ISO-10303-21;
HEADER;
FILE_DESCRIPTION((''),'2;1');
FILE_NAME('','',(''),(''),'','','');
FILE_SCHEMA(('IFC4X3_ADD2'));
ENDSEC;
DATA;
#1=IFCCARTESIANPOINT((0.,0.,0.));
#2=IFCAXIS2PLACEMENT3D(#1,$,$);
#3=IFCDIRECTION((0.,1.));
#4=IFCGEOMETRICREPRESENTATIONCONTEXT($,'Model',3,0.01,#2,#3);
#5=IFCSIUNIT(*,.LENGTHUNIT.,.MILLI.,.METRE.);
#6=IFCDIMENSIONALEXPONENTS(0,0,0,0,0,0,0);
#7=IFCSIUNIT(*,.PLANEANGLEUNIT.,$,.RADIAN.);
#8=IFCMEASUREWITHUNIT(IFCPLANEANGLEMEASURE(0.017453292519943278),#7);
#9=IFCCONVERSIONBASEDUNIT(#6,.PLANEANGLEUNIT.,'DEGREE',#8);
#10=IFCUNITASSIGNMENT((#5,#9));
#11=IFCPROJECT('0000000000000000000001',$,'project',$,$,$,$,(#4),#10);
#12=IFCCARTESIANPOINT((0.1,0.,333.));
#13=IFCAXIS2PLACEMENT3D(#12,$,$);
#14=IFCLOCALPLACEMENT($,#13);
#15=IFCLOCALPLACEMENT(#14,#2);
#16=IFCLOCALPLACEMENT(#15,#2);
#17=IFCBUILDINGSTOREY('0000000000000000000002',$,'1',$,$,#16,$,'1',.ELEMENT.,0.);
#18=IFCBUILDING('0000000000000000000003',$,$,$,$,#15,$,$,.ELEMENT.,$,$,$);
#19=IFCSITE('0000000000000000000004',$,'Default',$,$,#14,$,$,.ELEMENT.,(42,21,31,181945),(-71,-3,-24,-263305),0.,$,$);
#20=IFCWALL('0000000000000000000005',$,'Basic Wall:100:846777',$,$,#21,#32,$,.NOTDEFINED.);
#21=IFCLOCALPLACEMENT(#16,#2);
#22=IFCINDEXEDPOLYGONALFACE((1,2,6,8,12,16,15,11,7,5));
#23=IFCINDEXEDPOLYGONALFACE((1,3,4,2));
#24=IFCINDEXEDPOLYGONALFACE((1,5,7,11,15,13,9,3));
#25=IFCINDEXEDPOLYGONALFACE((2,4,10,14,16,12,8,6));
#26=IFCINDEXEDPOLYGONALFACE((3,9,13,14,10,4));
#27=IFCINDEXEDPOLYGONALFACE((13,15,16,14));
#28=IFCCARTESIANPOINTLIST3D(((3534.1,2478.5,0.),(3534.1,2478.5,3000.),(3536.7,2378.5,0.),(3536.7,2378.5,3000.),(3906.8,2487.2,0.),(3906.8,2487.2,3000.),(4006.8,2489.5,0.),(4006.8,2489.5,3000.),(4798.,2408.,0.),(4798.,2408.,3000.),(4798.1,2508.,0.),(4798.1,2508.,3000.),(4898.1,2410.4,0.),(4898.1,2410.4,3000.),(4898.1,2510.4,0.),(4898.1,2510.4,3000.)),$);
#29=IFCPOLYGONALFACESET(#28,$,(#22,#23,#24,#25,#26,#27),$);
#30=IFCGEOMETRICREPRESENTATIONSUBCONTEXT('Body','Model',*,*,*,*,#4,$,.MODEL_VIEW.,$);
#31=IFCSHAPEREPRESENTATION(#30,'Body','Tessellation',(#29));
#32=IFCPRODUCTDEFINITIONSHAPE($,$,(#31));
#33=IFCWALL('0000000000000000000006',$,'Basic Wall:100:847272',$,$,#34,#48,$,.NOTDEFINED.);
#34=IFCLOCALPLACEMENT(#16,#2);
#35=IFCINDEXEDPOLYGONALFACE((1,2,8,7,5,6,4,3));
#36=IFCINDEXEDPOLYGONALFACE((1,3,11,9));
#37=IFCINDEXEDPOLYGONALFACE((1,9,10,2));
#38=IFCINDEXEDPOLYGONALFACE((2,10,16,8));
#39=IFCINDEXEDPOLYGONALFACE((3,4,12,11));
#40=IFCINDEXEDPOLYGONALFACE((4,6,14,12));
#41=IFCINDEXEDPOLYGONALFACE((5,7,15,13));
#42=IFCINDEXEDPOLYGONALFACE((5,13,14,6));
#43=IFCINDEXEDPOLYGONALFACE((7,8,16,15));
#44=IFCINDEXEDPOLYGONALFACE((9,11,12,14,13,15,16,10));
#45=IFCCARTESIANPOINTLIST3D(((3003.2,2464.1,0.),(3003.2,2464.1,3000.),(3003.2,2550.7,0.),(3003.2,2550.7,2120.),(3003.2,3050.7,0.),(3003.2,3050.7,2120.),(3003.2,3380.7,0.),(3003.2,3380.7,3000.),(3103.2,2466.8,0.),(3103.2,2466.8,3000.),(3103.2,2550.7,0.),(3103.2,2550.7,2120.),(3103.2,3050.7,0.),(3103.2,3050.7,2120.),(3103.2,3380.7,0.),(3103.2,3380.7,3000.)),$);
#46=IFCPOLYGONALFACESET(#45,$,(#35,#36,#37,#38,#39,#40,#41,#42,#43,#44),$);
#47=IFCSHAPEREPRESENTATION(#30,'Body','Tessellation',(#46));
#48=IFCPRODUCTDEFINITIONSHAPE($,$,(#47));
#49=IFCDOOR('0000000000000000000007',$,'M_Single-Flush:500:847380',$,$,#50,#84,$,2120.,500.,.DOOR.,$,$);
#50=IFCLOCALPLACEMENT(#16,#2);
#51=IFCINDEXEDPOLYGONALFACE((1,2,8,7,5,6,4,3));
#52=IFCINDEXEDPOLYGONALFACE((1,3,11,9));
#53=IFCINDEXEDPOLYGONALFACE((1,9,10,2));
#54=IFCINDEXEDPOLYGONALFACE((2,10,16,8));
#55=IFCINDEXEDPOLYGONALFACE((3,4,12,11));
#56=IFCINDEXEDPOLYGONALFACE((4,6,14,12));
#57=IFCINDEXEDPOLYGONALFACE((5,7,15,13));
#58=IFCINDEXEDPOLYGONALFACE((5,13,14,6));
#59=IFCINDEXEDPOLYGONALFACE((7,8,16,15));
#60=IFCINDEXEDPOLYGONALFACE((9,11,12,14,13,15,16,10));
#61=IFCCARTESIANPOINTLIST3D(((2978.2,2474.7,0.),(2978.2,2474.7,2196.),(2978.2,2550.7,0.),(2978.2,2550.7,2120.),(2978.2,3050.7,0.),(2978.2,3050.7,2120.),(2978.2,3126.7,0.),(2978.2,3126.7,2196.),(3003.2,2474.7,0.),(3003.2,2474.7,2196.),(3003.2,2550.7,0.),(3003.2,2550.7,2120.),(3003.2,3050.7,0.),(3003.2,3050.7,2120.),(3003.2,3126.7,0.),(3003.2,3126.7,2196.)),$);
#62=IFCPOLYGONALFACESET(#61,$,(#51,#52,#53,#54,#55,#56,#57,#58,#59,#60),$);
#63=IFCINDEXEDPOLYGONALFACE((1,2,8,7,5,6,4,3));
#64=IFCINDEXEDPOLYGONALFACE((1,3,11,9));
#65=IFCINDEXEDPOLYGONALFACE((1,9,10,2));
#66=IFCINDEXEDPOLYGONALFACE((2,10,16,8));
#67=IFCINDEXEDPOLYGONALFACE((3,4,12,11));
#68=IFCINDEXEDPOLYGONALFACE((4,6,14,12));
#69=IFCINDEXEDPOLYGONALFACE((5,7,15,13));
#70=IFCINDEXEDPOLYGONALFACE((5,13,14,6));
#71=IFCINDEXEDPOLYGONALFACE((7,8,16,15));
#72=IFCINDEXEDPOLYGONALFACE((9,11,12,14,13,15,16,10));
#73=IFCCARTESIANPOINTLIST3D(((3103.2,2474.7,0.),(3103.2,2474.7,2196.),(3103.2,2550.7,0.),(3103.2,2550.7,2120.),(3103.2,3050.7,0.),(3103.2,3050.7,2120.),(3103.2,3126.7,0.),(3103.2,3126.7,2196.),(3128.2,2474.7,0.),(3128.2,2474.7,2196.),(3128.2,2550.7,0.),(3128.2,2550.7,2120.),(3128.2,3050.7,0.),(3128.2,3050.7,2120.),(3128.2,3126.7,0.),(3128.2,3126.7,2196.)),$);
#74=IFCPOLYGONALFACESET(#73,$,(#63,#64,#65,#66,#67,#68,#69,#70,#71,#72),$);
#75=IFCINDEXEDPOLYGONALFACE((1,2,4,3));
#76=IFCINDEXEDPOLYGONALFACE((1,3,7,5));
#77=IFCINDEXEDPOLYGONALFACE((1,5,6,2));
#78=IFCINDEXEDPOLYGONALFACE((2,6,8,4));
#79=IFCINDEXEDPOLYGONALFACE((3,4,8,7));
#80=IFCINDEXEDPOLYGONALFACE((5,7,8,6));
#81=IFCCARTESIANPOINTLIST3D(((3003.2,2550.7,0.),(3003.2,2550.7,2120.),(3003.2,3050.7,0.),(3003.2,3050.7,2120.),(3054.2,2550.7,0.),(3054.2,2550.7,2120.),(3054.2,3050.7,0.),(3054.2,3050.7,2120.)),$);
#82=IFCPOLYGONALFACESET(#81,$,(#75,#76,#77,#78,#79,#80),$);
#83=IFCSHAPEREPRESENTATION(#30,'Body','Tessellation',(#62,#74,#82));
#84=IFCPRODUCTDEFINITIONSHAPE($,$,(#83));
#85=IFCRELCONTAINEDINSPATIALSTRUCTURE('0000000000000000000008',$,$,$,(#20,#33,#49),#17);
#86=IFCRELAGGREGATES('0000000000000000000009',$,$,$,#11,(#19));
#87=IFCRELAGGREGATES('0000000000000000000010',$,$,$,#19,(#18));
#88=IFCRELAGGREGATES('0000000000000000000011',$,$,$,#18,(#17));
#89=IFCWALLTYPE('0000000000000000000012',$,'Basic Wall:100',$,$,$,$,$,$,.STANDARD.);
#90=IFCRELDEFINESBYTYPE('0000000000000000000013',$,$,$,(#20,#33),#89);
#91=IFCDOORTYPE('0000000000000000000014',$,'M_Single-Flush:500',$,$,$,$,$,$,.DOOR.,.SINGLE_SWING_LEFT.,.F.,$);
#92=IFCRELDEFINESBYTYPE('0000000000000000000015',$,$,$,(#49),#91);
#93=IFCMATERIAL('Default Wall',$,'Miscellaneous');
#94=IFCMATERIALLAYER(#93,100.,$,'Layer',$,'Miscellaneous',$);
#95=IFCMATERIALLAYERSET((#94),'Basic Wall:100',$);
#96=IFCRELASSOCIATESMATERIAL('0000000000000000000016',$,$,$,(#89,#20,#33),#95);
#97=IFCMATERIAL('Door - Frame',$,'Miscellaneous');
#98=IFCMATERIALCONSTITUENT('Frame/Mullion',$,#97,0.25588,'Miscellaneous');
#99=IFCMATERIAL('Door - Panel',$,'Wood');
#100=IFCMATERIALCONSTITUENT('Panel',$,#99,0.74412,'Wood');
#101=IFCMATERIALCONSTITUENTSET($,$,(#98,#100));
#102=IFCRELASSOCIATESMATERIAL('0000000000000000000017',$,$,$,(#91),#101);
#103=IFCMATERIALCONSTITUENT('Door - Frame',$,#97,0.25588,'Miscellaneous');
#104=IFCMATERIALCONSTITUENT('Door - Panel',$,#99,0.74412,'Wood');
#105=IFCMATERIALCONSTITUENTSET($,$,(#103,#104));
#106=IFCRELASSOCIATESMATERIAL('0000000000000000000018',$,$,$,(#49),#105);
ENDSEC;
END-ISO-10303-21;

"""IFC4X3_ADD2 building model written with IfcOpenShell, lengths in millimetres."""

from ifc_helpers import new_model, entity, si_unit, converted_unit, direction, frame, frame_2d, origin, origin_2d_with_axis, place, context, subcontext, project, spatial, polyline, rectangle, outline, extrude, source, transform, mapped, material, layer, layer_set, constituent, constituent_set, type_object, type_shapes, element, fill, save


model = new_model("IFC4X3_ADD2")

# Units and contexts
model_context = context("Model", 3, precision=0.01, world=origin(), true_north=direction((0.0, 1.0)))
body_context = subcontext(model_context, "Body", "Model", "MODEL_VIEW")
ifc_project = project(units=[si_unit("LENGTHUNIT", "METRE", prefix="MILLI"), converted_unit("PLANEANGLEUNIT", "DEGREE", entity("IfcPlaneAngleMeasure", 0.017453292519943278), si_unit("PLANEANGLEUNIT", "RADIAN"), dimensions=[0, 0, 0, 0, 0, 0, 0])], contexts=[model_context])

# Site, building, storey
site_placement = place(None, frame((0.1, 0.0, 333.0)))
site = spatial("IfcSite", under=ifc_project, at=site_placement, Name="Default", CompositionType="ELEMENT", RefLatitude=(42, 21, 31, 181945), RefLongitude=(-71, -3, -24, -263305), RefElevation=0.0)
building_placement = place(site_placement, origin())
building = spatial("IfcBuilding", under=site, at=building_placement, CompositionType="ELEMENT")
storey_placement = place(building_placement, origin())
storey = spatial("IfcBuildingStorey", under=building, at=storey_placement, Name="1", LongName="1", CompositionType="ELEMENT", Elevation=0.0)

# Shared definitions
ifc_material_1 = material(Name="Default Wall", Category="Miscellaneous")

# Shared definitions
ifc_layer_1 = layer(ifc_material_1, 100.0, Name="Layer", Category="Miscellaneous")
ifc_layer_set_1 = layer_set([ifc_layer_1], Name="Basic Wall:100")
wall_type_1 = type_object("IfcWallType", Name="Basic Wall:100", PredefinedType="STANDARD", material=ifc_layer_set_1)

# Shared definitions
ifc_material_2 = material(Name="Door - Frame", Category="Miscellaneous")
ifc_material_3 = material(Name="Door - Panel", Category="Wood")

# Wall
wall_1_placement = place(storey_placement, frame((3535.3, 2428.5, 0.0), z_axis=(0.0, 0.0, 1.0), x_axis=(0.999727, 0.023385, 0.0)))
element("IfcWall", 1, at=wall_1_placement, inside=storey, type_object=wall_type_1, material=ifc_layer_set_1, Name="Basic Wall:100:846777", PredefinedType="NOTDEFINED", context=body_context, shape_type="SweptSolid", body=[
    extrude(outline(polyline([(1362.0, -50.0), (1364.3, 50.0), (1264.3, 50.0), (472.8, 50.0), (372.8, 50.0), (0.0, 50.0), (0.2, -50.0), (1261.9, -50.0), (1362.0, -50.0)])), origin(), (0.0, 0.0, 1.0), 3000.0),
])

# Wall, opening, door
wall_2_placement = place(storey_placement, frame((3053.2, 3380.7, 0.0), z_axis=(0.0, 0.0, 1.0), x_axis=(0.0, -1.0, 0.0)))
wall_2 = element("IfcWall", 2, at=wall_2_placement, inside=storey, type_object=wall_type_1, material=ifc_layer_set_1, Name="Basic Wall:100:847272", PredefinedType="NOTDEFINED", context=body_context, shape_type="SweptSolid", body=[
    extrude(outline(polyline([(0.0, -50.0), (916.6, -50.0), (913.9, 50.0), (0.0, 50.0), (0.0, -50.0)])), origin(), (0.0, 0.0, 1.0), 3000.0),
])
opening_1_placement = place(wall_2_placement, frame((829.9, 50.0, 0.0)))
opening_1 = element("IfcOpeningElement", 3, at=opening_1_placement, cuts=wall_2, PredefinedType="OPENING", context=body_context, shape_type="SweptSolid", body=[
    extrude(rectangle(XDim=500.0, YDim=2120.0, at=frame_2d((1060.0, 250.0), x_axis=(0.0, -1.0))), frame((0.0, 0.0, 0.0), z_axis=(0.0, -1.0, 0.0), x_axis=(0.0, 0.0, 1.0)), (0.0, 0.0, 1.0), 100.0),
])
ifc_constituent_1 = constituent(ifc_material_2, Name="Door - Frame", Category="Miscellaneous", fraction=0.25588)
ifc_constituent_2 = constituent(ifc_material_3, Name="Door - Panel", Category="Wood", fraction=0.74412)
ifc_constituent_set_1 = constituent_set(constituents=[ifc_constituent_1, ifc_constituent_2])
ifc_constituent_3 = constituent(ifc_material_2, Name="Frame/Mullion", Category="Miscellaneous", fraction=0.25588)
ifc_constituent_4 = constituent(ifc_material_3, Name="Panel", Category="Wood", fraction=0.74412)
ifc_constituent_set_2 = constituent_set(constituents=[ifc_constituent_3, ifc_constituent_4])
door_type_1 = type_object("IfcDoorType", Name="M_Single-Flush:500", OperationType="SINGLE_SWING_LEFT", ParameterTakesPrecedence=False, PredefinedType="DOOR", material=ifc_constituent_set_2)
shared_shape_1 = source(origin(), body_context, "Body", "SweptSolid", [
    extrude(outline(polyline([(-326.0, -1117.0), (326.0, -1117.0), (326.0, 1079.0), (250.0, 1079.0), (250.0, -1041.0), (-250.0, -1041.0), (-250.0, 1079.0), (-326.0, 1079.0), (-326.0, -1117.0)])), frame((250.0, 125.0, 1079.0), z_axis=(0.0, -1.0, 0.0), x_axis=(-1.0, 0.0, 0.0)), (0.0, 0.0, 1.0), 25.0),
    extrude(outline(polyline([(-1117.0, -326.0), (1079.0, -326.0), (1079.0, -250.0), (-1041.0, -250.0), (-1041.0, 250.0), (1079.0, 250.0), (1079.0, 326.0), (-1117.0, 326.0), (-1117.0, -326.0)])), frame((250.0, 0.0, 1079.0), z_axis=(0.0, -1.0, 0.0), x_axis=(0.0, 0.0, -1.0)), (0.0, 0.0, 1.0), 25.0),
    extrude(rectangle(XDim=500.0, YDim=51.0, at=origin_2d_with_axis()), frame((250.0, 74.5, 0.0)), (0.0, 0.0, 1.0), 2120.0),
])
type_shapes(door_type_1, [shared_shape_1])
door_1_placement = place(opening_1_placement, frame((0.0, 0.0, 0.0), z_axis=(0.0, 0.0, 1.0), x_axis=(-1.0, 0.0, 0.0)))
door_1 = element("IfcDoor", 4, at=door_1_placement, inside=storey, type_object=door_type_1, material=ifc_constituent_set_1, Name="M_Single-Flush:500:847380", OverallHeight=2120.0, OverallWidth=500.0, PredefinedType="DOOR", context=body_context, shape_type="MappedRepresentation", body=[
    mapped(shared_shape_1, transform((0.0, 0.0, 0.0), scale=1.0)),
])
fill(opening_1, door_1)

save(model, "model.ifc")
